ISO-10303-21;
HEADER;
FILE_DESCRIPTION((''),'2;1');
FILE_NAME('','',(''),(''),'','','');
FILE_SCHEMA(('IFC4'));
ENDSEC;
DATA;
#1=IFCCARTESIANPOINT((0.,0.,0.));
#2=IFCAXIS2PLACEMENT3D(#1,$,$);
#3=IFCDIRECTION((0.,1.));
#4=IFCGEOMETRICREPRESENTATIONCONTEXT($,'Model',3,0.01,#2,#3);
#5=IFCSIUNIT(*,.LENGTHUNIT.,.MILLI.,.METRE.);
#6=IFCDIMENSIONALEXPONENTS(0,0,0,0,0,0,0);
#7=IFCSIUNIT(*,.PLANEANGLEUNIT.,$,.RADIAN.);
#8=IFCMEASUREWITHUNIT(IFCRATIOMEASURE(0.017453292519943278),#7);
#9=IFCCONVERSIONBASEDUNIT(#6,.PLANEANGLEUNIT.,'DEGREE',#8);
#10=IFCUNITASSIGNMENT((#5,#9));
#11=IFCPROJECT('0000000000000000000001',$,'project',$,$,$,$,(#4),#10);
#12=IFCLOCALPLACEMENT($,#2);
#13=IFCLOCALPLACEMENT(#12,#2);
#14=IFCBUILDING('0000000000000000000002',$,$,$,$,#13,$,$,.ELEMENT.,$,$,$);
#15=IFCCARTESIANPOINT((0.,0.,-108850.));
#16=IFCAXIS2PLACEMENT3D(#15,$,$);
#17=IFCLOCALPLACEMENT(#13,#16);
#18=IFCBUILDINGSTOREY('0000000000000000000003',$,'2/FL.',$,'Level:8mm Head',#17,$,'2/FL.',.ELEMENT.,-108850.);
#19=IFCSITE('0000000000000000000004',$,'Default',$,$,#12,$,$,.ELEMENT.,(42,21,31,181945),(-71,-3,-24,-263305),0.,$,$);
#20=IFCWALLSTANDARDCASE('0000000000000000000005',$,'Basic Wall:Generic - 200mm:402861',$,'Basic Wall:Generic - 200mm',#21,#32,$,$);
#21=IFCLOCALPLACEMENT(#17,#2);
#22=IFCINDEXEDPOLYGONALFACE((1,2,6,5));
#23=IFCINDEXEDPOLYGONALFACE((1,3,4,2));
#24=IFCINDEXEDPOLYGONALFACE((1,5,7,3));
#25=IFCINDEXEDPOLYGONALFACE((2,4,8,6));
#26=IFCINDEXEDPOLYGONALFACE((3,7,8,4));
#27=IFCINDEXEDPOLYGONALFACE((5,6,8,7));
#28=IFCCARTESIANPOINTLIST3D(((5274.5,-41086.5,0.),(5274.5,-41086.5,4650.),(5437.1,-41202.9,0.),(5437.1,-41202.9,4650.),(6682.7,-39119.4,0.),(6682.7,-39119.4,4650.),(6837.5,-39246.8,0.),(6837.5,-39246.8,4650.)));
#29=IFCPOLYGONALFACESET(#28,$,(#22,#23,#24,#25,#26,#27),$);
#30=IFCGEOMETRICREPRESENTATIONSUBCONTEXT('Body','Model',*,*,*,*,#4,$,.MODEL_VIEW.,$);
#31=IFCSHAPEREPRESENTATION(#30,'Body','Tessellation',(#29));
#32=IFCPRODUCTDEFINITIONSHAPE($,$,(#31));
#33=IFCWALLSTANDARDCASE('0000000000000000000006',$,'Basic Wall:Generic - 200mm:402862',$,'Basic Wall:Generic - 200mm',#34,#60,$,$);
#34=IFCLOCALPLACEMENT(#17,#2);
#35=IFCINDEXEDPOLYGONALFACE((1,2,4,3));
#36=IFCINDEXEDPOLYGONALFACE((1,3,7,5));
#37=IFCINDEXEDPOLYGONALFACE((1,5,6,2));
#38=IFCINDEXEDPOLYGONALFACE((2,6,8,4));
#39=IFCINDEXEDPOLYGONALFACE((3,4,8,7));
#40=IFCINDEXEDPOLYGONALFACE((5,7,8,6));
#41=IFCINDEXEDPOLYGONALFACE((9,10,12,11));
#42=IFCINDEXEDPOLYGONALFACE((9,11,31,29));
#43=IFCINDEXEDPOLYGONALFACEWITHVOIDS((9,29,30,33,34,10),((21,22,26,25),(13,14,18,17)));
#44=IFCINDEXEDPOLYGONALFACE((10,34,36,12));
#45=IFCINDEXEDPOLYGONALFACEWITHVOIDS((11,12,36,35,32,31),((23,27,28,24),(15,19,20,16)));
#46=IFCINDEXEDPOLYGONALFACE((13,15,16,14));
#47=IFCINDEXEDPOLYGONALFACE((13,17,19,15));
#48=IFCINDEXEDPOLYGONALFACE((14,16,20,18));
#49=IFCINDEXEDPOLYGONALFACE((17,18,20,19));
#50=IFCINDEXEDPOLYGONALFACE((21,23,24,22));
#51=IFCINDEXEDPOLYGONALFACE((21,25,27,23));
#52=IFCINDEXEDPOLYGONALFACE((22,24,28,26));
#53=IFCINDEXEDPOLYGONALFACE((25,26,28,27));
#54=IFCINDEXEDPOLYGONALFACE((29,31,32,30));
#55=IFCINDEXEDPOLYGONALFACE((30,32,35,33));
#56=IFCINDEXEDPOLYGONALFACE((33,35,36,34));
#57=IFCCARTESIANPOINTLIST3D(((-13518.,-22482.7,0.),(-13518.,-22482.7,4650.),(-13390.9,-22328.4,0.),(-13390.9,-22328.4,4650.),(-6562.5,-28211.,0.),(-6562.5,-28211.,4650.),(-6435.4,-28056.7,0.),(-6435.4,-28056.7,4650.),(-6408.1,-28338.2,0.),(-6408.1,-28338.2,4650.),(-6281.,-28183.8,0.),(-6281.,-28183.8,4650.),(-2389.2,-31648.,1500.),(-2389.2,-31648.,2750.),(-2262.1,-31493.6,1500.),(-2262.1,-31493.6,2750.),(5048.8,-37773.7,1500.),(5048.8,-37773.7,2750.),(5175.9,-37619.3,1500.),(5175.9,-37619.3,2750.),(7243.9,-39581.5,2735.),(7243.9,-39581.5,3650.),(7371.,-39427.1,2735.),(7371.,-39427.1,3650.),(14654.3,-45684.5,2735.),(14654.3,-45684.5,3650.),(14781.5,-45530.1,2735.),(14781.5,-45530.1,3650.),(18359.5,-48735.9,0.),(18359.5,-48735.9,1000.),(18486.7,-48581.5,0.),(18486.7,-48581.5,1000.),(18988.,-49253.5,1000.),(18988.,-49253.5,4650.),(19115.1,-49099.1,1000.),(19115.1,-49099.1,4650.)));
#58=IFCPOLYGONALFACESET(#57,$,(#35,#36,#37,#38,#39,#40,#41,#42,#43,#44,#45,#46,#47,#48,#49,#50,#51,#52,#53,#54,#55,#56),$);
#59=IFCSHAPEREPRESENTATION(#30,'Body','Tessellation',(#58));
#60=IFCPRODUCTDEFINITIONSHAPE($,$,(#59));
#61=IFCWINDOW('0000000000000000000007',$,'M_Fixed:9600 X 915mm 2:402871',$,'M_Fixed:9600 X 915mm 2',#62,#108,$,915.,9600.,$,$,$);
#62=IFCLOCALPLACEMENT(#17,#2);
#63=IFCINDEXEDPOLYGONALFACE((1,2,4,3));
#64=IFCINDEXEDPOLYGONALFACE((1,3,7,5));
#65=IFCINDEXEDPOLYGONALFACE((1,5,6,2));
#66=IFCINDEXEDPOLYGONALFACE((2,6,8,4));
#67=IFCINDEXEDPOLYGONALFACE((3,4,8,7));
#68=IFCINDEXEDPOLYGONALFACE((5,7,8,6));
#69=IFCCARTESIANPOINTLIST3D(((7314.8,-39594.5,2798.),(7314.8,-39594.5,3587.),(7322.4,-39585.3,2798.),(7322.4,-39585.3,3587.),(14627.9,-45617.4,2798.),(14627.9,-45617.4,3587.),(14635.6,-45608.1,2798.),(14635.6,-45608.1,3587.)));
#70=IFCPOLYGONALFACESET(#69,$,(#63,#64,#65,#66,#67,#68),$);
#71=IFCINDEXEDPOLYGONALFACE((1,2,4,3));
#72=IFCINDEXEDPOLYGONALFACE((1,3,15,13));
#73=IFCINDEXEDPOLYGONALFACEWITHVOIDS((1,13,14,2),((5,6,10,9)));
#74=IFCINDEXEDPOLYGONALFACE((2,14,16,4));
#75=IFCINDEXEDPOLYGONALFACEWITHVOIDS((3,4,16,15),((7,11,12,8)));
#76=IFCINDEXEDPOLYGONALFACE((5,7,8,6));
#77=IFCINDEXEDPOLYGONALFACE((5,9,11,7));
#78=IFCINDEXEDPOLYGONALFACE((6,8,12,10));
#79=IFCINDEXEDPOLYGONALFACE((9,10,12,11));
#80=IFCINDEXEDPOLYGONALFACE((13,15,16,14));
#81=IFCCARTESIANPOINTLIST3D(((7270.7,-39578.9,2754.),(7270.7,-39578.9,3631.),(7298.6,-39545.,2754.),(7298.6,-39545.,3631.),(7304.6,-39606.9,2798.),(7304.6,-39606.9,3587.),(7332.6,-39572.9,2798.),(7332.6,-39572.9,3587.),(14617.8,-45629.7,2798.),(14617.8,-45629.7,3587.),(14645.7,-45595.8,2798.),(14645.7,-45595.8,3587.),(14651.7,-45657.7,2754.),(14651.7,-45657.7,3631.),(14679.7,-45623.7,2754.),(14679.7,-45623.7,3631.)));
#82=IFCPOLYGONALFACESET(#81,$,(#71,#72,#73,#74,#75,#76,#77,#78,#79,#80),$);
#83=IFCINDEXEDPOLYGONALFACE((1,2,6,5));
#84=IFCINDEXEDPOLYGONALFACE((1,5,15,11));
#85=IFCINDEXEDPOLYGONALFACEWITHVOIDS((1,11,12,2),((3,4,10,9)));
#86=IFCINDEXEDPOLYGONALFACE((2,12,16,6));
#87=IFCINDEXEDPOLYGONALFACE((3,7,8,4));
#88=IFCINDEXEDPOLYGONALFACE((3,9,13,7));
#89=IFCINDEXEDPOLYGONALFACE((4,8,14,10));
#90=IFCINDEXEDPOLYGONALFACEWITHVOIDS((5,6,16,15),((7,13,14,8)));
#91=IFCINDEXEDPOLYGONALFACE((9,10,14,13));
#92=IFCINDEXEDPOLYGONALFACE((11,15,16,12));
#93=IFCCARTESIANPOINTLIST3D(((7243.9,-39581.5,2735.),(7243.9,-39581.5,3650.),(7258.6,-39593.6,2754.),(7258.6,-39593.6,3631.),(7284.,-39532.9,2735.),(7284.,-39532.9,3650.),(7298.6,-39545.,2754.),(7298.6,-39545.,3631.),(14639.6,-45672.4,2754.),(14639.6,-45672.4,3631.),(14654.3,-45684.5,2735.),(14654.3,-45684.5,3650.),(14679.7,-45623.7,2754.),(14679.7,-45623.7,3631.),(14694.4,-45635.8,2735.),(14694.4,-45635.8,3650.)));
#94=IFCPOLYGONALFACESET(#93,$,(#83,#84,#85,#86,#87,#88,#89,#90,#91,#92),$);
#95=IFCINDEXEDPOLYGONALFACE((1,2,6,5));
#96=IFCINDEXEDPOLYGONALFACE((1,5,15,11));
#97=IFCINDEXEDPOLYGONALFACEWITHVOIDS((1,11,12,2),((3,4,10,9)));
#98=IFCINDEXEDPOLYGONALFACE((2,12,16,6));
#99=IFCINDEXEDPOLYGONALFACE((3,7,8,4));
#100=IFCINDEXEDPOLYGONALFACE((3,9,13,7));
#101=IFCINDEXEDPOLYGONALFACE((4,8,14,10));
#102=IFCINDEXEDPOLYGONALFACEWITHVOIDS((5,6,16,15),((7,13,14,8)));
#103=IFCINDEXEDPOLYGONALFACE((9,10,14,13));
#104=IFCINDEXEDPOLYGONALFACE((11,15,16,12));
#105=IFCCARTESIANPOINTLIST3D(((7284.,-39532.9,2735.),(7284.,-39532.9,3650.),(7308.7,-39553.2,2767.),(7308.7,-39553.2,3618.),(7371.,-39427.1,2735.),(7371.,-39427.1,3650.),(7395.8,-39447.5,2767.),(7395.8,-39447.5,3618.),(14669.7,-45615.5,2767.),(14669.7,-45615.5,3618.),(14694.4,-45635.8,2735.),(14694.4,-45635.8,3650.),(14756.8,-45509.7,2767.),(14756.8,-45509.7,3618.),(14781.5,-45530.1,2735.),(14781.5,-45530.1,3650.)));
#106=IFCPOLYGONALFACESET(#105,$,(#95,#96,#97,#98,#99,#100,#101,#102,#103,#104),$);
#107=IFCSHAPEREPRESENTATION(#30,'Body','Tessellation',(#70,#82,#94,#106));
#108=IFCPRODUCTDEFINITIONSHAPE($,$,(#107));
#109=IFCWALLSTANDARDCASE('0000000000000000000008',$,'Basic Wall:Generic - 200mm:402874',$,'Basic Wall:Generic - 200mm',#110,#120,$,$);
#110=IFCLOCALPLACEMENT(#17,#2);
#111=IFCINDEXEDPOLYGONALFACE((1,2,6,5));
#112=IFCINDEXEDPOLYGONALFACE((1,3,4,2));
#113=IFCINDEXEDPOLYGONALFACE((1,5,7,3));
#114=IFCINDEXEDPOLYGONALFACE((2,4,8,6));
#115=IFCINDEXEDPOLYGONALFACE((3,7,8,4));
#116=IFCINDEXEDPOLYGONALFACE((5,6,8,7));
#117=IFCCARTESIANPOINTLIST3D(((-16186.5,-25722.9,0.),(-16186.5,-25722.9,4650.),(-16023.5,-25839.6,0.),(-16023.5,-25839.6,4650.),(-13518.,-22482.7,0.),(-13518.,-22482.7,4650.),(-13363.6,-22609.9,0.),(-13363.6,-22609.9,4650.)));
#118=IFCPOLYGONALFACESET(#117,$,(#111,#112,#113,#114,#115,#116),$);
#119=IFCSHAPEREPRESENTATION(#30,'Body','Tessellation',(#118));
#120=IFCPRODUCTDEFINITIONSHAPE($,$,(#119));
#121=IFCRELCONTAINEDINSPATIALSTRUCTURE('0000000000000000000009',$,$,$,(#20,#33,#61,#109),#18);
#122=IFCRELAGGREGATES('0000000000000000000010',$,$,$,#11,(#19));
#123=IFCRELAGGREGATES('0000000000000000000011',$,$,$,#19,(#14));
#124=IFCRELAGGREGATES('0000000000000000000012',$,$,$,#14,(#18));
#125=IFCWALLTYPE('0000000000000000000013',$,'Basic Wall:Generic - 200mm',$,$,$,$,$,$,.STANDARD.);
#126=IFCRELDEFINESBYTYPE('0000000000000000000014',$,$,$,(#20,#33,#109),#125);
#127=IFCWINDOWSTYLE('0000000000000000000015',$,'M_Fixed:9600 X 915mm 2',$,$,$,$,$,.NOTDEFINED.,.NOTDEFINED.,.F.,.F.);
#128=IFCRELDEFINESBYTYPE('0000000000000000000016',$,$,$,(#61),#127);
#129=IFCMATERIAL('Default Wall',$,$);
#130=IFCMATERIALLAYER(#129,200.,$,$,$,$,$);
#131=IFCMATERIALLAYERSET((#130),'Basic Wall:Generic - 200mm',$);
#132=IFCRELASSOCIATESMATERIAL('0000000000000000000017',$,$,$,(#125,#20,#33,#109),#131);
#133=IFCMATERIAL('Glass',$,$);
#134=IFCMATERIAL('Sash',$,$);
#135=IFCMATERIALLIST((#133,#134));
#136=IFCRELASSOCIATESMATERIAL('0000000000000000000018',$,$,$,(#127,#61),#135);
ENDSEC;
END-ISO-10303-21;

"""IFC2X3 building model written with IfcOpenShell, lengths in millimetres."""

from ifc_helpers import new_model, entity, si_unit, converted_unit, direction, frame, frame_2d, origin, place, context, subcontext, project, spatial, polyline, rectangle, outline, extrude, source, transform, mapped, material, material_list, layer, layer_set, layer_usage, type_object, type_shapes, element, fill, save


model = new_model("IFC2X3")

# Units and contexts
model_context = context("Model", 3, precision=0.01, world=origin(), true_north=direction((0.0, 1.0)))
body_context = subcontext(model_context, "Body", "Model", "MODEL_VIEW")
ifc_project = project(units=[si_unit("LENGTHUNIT", "METRE", prefix="MILLI"), converted_unit("PLANEANGLEUNIT", "DEGREE", entity("IfcRatioMeasure", 0.017453292519943278), si_unit("PLANEANGLEUNIT", "RADIAN"), dimensions=[0, 0, 0, 0, 0, 0, 0])], contexts=[model_context])

# Site, building, storey
site_placement = place(None, origin())
site = spatial("IfcSite", under=ifc_project, at=site_placement, Name="Default", CompositionType="ELEMENT", RefLatitude=(42, 21, 31, 181945), RefLongitude=(-71, -3, -24, -263305), RefElevation=0.0)
building_placement = place(site_placement, origin())
building = spatial("IfcBuilding", under=site, at=building_placement, CompositionType="ELEMENT")
storey_placement = place(building_placement, frame((0.0, 0.0, -108850.0)))
storey = spatial("IfcBuildingStorey", under=building, at=storey_placement, Name="2/FL.", ObjectType="Level:8mm Head", LongName="2/FL.", CompositionType="ELEMENT", Elevation=-108850.0)

# Shared definitions
ifc_material_1 = material(Name="Default Wall")
ifc_layer = layer(ifc_material_1, 200.0)
ifc_layer_set = layer_set([ifc_layer], Name="Basic Wall:Generic - 200mm")
ifc_layer_usage = layer_usage(ifc_layer_set, "AXIS2", "NEGATIVE", 100.0)
wall_type = type_object("IfcWallType", Name="Basic Wall:Generic - 200mm", PredefinedType="STANDARD", material=ifc_layer_set)

# Shared definitions
ifc_material_2 = material(Name="Glass")
ifc_material_3 = material(Name="Sash")
ifc_material_list = material_list([ifc_material_2, ifc_material_3])

# Wall
wall_1_placement = place(storey_placement, frame((5355.8, -41144.7, 0.0), z_axis=(0.0, 0.0, 1.0), x_axis=(0.582098, 0.813119, 0.0)))
element("IfcWallStandardCase", 1, at=wall_1_placement, inside=storey, type_object=wall_type, material=ifc_layer_usage, Name="Basic Wall:Generic - 200mm:402861", ObjectType="Basic Wall:Generic - 200mm", context=body_context, shape_type="SweptSolid", body=[
    extrude(outline(polyline([(2405.7, -100.0), (2419.3, 100.0), (0.0, 100.0), (0.0, -100.0), (2405.7, -100.0)])), origin(), (0.0, 0.0, 1.0), 4650.0),
])

# Wall, openings, window
wall_2_placement = place(storey_placement, frame((-13454.4, -22405.5, 0.0), z_axis=(0.0, 0.0, 1.0), x_axis=(0.771917, -0.635723, 0.0)))
wall_2 = element("IfcWallStandardCase", 2, at=wall_2_placement, inside=storey, type_object=wall_type, material=ifc_layer_usage, Name="Basic Wall:Generic - 200mm:402862", ObjectType="Basic Wall:Generic - 200mm", context=body_context, shape_type="SweptSolid", body=[
    extrude(rectangle(XDim=42110.7, YDim=200.0, at=frame_2d((21055.3, 0.0), x_axis=(-1.0, 0.0))), origin(), (0.0, 0.0, 1.0), 4650.0),
])
opening_1_placement = place(storey_placement, frame((-13454.4, -22405.5, 0.0), z_axis=(0.0, 0.0, 1.0), x_axis=(0.771917, -0.635723, 0.0)))
element("IfcOpeningElement", 3, at=opening_1_placement, cuts=wall_2, ObjectType="Opening", context=body_context, shape_type="SweptSolid", body=[
    extrude(rectangle(XDim=4650.0, YDim=200.0, at=frame_2d((-465.0, -10.0), x_axis=(1.0, 0.0))), frame((9010.7, 10.0, 1860.0), z_axis=(1.0, 0.0, 0.0), x_axis=(0.0, 0.0, -1.0)), (0.0, 0.0, 1.0), 200.0),
])
opening_2_placement = place(wall_2_placement, origin())
element("IfcOpeningElement", 4, at=opening_2_placement, cuts=wall_2, ObjectType="Opening", context=body_context, shape_type="SweptSolid", body=[
    extrude(rectangle(XDim=1250.0, YDim=9635.8, at=frame_2d((0.0, 0.0), x_axis=(1.0, 0.0))), frame((19234.9, -100.0, 2125.0), z_axis=(0.0, 1.0, 0.0), x_axis=(0.0, 0.0, -1.0)), (0.0, 0.0, 1.0), 200.0),
])
opening_3_placement = place(wall_2_placement, frame((-3858.0, 25848.5, 0.0), z_axis=(0.0, 0.0, 1.0), x_axis=(0.771917, 0.635723, 0.0)))
element("IfcOpeningElement", 5, at=opening_3_placement, cuts=wall_2, ObjectType="Opening", context=body_context, shape_type="SweptSolid", body=[
    extrude(rectangle(XDim=1000.0, YDim=1010.1, at=frame_2d((0.0, 0.0), x_axis=(1.0, 0.0))), frame((18741.3, -49066.8, 500.0), z_axis=(0.635723, 0.771917, 0.0), x_axis=(0.0, 0.0, -1.0)), (0.0, 0.0, 1.0), 1012.7),
])
opening_4_placement = place(wall_2_placement, frame((36496.6, 100.0, 2735.0)))
opening_4 = element("IfcOpeningElement", 6, at=opening_4_placement, cuts=wall_2, ObjectType="Opening", context=body_context, shape_type="SweptSolid", body=[
    extrude(rectangle(XDim=915.0, YDim=9600.0, at=frame_2d((457.5, 4800.0), x_axis=(1.0, 0.0))), frame((0.0, 0.0, 0.0), z_axis=(0.0, -1.0, 0.0), x_axis=(0.0, 0.0, 1.0)), (0.0, 0.0, 1.0), 200.0),
])
window_style_1 = type_object("IfcWindowStyle", Name="M_Fixed:9600 X 915mm 2", ConstructionType="NOTDEFINED", OperationType="NOTDEFINED", ParameterTakesPrecedence=False, Sizeable=False, material=ifc_material_list)
shared_shape_1 = source(origin(), body_context, "Body", "SweptSolid", [
    extrude(rectangle(XDim=12.0, YDim=9474.0, at=frame_2d((0.0, 0.0), x_axis=(1.0, 0.0))), frame((4800.0, 159.0, 63.0), z_axis=(0.0, 0.0, 1.0), x_axis=(0.0, -1.0, 0.0)), (0.0, 0.0, 1.0), 789.0),
    extrude(outline(polyline([(-4781.0, -438.5), (4781.0, -438.5), (4781.0, 438.5), (-4781.0, 438.5), (-4781.0, -438.5)]), holes=[polyline([(-4737.0, -394.5), (-4737.0, 394.5), (4737.0, 394.5), (4737.0, -394.5), (-4737.0, -394.5)])]), frame((4800.0, 137.0, 457.5), z_axis=(0.0, 1.0, 0.0), x_axis=(1.0, 0.0, 0.0)), (0.0, 0.0, 1.0), 44.0),
    extrude(outline(polyline([(-4800.0, -457.5), (4800.0, -457.5), (4800.0, 457.5), (-4800.0, 457.5), (-4800.0, -457.5)]), holes=[polyline([(-4781.0, -438.5), (-4781.0, 438.5), (4781.0, 438.5), (4781.0, -438.5), (-4781.0, -438.5)])]), frame((4800.0, 137.0, 457.5), z_axis=(0.0, 1.0, 0.0), x_axis=(1.0, 0.0, 0.0)), (0.0, 0.0, 1.0), 63.0),
    extrude(outline(polyline([(-4800.0, -457.5), (4800.0, -457.5), (4800.0, 457.5), (-4800.0, 457.5), (-4800.0, -457.5)]), holes=[polyline([(-4768.0, -425.5), (-4768.0, 425.5), (4768.0, 425.5), (4768.0, -425.5), (-4768.0, -425.5)])]), frame((4800.0, 0.0, 457.5), z_axis=(0.0, 1.0, 0.0), x_axis=(1.0, 0.0, 0.0)), (0.0, 0.0, 1.0), 137.0),
])
type_shapes(window_style_1, [shared_shape_1])
window_1_placement = place(opening_4_placement, frame((0.0, 0.0, 0.0), z_axis=(0.0, 0.0, 1.0), x_axis=(-1.0, 0.0, 0.0)))
window_1 = element("IfcWindow", 7, at=window_1_placement, inside=storey, type_object=window_style_1, material=ifc_material_list, Name="M_Fixed:9600 X 915mm 2:402871", ObjectType="M_Fixed:9600 X 915mm 2", OverallHeight=915.0, OverallWidth=9600.0, context=body_context, shape_type="MappedRepresentation", body=[
    mapped(shared_shape_1, transform((0.0, 0.0, 0.0), scale=1.0)),
])
fill(opening_4, window_1)

# Wall
wall_3_placement = place(storey_placement, frame((-16109.3, -25786.5, 0.0), z_axis=(0.0, 0.0, 1.0), x_axis=(0.635723, 0.771917, 0.0)))
element("IfcWallStandardCase", 8, at=wall_3_placement, inside=storey, type_object=wall_type, material=ifc_layer_usage, Name="Basic Wall:Generic - 200mm:402874", ObjectType="Basic Wall:Generic - 200mm", context=body_context, shape_type="SweptSolid", body=[
    extrude(outline(polyline([(4197.6, -100.0), (4197.6, 100.0), (0.0, 100.0), (13.5, -100.0), (4197.6, -100.0)])), origin(), (0.0, 0.0, 1.0), 4650.0),
])

save(model, "model.ifc")
